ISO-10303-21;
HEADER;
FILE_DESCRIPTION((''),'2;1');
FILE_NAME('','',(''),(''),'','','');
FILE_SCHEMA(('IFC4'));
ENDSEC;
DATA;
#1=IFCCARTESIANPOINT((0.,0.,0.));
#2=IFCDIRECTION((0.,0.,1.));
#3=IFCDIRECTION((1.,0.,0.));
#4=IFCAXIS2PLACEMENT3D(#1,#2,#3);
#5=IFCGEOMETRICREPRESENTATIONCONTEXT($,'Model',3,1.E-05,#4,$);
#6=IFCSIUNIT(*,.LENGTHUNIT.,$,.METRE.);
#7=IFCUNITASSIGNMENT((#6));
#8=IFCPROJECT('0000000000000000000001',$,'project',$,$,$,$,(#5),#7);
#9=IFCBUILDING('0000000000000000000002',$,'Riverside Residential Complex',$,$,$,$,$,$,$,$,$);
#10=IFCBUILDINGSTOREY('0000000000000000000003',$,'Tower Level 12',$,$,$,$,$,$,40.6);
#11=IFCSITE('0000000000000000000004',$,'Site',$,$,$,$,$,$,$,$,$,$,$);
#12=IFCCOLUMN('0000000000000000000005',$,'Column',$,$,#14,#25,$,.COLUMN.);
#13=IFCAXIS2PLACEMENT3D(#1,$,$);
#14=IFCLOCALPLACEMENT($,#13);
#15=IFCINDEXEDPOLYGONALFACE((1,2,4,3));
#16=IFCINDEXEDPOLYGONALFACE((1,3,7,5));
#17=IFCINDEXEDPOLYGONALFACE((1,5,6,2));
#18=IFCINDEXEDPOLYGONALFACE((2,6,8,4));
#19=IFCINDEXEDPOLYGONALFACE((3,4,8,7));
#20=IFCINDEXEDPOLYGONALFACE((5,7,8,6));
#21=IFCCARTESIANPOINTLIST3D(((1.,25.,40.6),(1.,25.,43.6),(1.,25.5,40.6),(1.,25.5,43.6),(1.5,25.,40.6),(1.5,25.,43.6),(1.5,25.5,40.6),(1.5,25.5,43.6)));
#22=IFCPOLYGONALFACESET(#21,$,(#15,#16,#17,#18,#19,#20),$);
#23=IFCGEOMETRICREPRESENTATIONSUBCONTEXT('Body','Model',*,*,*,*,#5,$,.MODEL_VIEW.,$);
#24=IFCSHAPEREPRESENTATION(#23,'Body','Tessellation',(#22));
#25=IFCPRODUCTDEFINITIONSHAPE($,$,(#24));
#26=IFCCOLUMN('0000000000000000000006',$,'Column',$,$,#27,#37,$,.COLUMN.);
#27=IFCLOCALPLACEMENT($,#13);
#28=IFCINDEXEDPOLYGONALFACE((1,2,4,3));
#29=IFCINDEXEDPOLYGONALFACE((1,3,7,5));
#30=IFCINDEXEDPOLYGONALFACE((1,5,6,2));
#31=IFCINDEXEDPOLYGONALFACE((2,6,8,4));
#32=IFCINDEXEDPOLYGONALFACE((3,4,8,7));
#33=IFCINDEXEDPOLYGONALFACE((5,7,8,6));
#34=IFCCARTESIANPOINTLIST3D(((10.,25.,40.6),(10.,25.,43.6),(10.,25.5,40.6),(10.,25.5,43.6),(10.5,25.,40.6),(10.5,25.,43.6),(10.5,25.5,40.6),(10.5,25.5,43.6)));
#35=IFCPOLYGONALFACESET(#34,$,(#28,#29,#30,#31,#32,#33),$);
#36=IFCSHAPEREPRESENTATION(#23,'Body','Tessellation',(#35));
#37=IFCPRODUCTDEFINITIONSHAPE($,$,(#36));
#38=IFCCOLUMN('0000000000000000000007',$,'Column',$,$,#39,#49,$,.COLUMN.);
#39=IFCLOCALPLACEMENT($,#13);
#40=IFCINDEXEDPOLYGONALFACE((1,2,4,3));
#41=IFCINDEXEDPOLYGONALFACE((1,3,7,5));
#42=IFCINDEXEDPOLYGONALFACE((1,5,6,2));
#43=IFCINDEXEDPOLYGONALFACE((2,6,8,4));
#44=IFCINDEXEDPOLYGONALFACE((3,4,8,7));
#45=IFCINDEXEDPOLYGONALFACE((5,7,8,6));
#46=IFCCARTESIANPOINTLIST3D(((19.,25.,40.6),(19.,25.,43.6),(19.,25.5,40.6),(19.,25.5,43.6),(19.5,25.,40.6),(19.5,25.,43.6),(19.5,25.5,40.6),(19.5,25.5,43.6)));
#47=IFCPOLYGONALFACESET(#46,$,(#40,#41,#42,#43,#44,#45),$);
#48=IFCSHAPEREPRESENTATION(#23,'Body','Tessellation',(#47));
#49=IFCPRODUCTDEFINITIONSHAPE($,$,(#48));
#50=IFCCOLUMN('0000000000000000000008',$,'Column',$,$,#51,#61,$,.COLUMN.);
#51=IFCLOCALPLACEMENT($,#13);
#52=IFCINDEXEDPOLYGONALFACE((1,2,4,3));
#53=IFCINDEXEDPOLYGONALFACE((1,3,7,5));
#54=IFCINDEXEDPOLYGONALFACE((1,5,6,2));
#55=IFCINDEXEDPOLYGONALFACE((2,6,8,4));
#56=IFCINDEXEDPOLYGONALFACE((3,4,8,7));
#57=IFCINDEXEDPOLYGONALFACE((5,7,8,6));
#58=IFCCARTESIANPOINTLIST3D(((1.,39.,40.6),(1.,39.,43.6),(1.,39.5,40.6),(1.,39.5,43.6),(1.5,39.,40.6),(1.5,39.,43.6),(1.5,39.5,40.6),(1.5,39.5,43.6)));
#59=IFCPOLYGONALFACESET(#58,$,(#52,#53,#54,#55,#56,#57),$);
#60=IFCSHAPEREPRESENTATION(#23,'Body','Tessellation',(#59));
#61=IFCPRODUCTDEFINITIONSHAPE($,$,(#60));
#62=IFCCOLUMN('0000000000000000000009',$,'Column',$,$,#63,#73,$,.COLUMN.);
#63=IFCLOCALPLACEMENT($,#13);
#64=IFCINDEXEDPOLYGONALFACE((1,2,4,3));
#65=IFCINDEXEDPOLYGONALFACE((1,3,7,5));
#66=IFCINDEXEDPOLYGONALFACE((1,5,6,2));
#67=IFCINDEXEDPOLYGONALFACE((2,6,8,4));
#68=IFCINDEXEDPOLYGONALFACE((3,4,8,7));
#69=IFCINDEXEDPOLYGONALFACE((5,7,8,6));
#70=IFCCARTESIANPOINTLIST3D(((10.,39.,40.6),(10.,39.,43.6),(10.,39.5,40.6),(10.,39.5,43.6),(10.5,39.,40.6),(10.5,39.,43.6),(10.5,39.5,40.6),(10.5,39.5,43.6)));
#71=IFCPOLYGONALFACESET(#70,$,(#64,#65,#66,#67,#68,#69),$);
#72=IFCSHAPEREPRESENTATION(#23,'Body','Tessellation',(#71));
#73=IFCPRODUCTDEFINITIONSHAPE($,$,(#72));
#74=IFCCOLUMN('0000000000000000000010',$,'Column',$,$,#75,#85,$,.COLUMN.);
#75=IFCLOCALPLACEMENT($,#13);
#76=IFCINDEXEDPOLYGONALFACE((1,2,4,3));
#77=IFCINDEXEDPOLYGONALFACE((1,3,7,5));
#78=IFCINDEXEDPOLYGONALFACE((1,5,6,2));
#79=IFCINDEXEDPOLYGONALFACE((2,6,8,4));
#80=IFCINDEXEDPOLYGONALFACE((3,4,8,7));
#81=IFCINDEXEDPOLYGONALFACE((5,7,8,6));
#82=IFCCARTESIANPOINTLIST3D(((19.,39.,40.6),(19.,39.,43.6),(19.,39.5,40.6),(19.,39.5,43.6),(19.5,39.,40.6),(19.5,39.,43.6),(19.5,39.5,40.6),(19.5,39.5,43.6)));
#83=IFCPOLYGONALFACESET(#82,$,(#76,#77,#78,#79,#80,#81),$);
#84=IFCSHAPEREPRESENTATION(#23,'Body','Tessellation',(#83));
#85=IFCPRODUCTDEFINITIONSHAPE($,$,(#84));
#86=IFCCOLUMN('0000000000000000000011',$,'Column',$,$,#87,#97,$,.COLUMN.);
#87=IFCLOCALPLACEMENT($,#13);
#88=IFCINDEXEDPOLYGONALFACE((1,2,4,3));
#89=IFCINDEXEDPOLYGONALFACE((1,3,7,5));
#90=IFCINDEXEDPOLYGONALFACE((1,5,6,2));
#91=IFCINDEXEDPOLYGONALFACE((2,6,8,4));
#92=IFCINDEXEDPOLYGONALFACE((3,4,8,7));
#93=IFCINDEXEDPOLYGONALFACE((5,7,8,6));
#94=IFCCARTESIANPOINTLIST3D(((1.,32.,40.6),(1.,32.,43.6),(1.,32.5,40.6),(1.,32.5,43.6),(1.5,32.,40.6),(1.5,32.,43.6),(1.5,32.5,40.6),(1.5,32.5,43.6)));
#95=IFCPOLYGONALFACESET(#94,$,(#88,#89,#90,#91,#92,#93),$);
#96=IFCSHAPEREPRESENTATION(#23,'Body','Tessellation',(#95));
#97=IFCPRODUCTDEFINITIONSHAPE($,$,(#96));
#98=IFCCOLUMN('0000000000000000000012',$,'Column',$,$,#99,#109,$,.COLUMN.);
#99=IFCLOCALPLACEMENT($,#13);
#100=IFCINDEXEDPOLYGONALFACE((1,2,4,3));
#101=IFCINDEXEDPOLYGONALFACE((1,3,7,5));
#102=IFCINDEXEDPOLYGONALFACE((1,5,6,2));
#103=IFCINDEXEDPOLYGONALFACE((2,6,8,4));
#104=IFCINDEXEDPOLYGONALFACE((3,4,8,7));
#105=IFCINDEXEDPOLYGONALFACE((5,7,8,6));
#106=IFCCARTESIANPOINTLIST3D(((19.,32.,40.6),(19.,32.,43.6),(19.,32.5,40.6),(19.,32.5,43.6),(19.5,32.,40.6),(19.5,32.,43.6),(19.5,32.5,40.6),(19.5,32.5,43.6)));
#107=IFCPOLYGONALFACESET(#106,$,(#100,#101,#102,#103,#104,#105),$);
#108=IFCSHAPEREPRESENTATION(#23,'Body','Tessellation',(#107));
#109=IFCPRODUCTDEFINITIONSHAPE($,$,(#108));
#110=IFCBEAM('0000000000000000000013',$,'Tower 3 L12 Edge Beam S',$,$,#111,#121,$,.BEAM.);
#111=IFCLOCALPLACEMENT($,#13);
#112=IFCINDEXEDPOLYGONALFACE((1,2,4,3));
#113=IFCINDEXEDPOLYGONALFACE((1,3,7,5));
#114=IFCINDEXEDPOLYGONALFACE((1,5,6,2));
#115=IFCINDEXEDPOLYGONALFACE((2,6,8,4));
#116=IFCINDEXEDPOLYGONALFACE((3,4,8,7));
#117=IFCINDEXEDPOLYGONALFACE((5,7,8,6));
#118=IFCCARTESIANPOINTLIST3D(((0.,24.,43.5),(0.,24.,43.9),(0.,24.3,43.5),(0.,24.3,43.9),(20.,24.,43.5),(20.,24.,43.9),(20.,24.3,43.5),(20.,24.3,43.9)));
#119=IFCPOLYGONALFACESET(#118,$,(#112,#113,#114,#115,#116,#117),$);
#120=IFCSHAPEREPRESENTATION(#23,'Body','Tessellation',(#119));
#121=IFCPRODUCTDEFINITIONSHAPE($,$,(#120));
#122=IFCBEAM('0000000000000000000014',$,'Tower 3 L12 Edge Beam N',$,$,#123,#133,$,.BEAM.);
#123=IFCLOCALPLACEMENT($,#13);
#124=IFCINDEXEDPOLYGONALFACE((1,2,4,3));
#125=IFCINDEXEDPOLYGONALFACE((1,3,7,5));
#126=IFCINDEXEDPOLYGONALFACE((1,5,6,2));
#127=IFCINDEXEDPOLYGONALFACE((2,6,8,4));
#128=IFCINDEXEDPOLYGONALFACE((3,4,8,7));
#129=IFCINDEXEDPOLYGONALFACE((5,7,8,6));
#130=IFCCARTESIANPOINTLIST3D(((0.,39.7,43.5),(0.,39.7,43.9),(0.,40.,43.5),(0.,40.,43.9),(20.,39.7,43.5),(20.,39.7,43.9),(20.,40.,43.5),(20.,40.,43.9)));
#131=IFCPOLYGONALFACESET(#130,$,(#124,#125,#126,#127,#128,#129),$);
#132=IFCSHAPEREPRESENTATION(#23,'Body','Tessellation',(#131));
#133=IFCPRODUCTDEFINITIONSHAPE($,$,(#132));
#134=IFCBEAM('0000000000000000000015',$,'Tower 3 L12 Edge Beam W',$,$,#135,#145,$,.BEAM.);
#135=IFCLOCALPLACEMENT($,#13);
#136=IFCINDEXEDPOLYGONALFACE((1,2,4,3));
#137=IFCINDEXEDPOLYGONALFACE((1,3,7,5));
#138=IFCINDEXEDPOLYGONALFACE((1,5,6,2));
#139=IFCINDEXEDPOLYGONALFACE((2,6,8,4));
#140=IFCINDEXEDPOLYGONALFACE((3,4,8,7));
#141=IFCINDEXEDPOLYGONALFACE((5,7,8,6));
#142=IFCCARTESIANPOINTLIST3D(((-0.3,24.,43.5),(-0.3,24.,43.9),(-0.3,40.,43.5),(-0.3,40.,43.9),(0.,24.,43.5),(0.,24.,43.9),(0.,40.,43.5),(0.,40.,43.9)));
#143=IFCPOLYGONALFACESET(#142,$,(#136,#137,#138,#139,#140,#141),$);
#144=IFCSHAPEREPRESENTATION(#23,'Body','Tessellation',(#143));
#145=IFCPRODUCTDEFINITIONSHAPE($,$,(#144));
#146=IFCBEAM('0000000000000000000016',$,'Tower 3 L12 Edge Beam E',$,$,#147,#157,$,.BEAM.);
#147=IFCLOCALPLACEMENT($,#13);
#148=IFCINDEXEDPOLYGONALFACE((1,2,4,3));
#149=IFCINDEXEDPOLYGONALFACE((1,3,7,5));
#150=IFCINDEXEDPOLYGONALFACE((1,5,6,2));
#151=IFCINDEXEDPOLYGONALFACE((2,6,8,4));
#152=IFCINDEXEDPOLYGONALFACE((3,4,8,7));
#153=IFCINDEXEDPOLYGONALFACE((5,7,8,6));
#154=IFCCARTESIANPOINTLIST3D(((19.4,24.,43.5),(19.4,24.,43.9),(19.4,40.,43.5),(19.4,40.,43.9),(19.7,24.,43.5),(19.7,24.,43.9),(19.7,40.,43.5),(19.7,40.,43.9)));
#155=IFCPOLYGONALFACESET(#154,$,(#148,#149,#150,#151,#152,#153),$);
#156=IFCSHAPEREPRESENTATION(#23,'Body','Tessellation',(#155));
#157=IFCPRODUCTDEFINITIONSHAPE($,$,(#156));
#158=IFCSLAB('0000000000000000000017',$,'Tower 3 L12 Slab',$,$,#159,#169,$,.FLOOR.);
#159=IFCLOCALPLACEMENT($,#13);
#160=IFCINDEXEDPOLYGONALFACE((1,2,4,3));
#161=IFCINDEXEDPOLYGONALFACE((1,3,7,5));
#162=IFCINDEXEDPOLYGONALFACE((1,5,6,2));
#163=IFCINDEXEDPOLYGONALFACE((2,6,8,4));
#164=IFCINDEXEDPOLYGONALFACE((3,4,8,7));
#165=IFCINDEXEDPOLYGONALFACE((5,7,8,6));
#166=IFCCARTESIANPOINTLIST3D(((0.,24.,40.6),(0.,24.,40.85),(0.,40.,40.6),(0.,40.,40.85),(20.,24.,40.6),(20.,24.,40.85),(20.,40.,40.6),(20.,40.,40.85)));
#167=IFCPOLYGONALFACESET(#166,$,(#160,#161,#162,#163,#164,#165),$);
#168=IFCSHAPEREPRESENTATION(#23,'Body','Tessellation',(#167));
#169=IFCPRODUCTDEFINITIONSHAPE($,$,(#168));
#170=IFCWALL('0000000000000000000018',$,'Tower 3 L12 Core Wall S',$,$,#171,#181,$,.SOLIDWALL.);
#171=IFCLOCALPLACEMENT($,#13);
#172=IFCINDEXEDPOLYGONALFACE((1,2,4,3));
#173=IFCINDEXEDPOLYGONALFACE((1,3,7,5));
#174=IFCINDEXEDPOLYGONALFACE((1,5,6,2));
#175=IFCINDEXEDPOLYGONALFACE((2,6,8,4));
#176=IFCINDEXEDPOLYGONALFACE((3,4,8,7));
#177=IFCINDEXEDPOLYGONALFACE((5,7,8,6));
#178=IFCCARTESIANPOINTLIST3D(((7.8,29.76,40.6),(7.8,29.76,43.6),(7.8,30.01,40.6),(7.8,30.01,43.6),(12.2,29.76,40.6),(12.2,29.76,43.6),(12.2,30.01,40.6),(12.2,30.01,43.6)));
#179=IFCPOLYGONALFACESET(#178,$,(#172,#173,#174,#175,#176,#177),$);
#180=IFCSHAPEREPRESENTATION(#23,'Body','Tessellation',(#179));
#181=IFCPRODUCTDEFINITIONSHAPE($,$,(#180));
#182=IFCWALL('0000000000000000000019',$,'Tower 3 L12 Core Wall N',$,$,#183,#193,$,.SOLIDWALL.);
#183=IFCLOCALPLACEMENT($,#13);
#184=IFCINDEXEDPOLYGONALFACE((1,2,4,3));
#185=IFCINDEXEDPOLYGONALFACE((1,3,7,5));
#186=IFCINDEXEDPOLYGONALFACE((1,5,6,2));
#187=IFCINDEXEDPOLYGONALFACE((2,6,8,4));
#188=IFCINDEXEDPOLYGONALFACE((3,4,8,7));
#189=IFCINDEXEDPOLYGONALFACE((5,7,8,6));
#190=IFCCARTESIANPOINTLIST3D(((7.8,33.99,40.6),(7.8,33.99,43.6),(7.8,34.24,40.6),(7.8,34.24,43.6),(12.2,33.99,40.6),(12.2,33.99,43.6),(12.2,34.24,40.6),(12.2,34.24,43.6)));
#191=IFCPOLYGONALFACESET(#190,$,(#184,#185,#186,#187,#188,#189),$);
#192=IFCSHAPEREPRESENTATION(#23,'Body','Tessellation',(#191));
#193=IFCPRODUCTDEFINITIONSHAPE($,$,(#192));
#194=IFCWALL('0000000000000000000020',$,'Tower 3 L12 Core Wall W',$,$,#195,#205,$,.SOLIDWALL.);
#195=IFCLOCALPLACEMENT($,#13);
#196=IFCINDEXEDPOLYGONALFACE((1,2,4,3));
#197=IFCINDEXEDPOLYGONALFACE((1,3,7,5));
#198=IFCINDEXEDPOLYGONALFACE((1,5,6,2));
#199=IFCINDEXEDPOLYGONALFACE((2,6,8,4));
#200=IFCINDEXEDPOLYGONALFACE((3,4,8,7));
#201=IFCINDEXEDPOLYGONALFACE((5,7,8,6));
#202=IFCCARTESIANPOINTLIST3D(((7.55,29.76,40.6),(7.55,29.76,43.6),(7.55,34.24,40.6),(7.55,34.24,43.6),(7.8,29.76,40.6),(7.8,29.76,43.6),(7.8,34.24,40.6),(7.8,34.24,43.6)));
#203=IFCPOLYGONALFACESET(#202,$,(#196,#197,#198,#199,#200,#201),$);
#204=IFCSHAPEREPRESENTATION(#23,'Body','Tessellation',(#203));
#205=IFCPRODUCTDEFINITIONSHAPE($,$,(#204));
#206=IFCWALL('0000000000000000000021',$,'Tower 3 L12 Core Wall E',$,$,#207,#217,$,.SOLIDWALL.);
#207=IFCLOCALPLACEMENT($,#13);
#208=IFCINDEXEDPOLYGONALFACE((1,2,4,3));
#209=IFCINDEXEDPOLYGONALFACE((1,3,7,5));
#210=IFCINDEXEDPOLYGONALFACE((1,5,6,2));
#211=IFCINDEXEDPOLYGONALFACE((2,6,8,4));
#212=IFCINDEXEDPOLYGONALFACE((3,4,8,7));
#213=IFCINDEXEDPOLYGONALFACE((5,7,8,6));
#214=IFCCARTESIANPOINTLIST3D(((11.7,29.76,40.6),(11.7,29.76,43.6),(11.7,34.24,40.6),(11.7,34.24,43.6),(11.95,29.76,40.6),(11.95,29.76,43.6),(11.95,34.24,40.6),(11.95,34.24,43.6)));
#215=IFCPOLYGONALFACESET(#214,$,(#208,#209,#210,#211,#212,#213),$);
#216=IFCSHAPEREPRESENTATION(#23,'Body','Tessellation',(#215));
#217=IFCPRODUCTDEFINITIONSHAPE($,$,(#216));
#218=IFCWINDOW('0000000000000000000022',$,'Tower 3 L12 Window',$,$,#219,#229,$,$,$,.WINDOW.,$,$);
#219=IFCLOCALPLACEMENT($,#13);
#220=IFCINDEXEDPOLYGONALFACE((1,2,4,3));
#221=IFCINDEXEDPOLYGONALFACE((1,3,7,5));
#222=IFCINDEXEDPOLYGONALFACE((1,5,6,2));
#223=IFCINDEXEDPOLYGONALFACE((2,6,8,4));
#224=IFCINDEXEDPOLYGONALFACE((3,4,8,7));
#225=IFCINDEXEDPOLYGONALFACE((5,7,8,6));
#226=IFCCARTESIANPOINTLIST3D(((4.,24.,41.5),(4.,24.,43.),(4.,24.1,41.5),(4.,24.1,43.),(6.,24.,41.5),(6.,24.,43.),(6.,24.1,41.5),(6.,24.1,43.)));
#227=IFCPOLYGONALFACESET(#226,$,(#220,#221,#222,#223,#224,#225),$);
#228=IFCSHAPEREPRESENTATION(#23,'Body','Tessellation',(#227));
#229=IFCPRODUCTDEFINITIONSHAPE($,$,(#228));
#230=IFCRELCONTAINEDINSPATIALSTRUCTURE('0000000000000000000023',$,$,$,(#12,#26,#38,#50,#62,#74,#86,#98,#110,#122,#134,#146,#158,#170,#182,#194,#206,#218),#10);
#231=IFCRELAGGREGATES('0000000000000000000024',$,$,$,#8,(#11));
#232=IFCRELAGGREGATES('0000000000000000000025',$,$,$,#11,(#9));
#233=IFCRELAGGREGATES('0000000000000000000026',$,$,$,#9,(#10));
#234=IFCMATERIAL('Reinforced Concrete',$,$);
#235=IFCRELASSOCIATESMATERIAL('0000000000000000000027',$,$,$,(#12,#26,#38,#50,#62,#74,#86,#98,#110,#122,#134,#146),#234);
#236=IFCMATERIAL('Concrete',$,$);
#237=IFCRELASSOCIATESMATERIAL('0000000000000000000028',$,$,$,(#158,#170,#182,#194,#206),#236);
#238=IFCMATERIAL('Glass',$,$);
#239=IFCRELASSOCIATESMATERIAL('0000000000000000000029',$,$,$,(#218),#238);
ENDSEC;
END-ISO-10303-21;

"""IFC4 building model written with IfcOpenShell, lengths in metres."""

from ifc_helpers import new_model, si_unit, frame, origin_with_axes, place, context, subcontext, project, spatial, line, indexed_curve, outline, extrude, material, element, save


model = new_model("IFC4")

# Units and contexts
model_context = context("Model", 3, precision=1e-05, world=origin_with_axes())
body_context = subcontext(model_context, "Body", "Model", "MODEL_VIEW")
ifc_project = project(units=[si_unit("LENGTHUNIT", "METRE")], contexts=[model_context])

# Site, building, storey
site = spatial("IfcSite", under=ifc_project, Name="Site")
building = spatial("IfcBuilding", under=site, Name="Riverside Residential Complex")
storey = spatial("IfcBuildingStorey", under=building, Name="Tower Level 12", Elevation=40.6)

# Columns
ifc_material_1 = material(Name="Reinforced Concrete")
for number, where, z_axis, x_axis, name in (
    (1, (1.0, 25.0, 40.6), (0.0, 0.0, 1.0), (1.0, 0.0, 0.0), "Column"),
    (2, (10.0, 25.0, 40.6), (0.0, 0.0, 1.0), (1.0, 0.0, 0.0), "Column"),
    (3, (19.0, 25.0, 40.6), (0.0, 0.0, 1.0), (1.0, 0.0, 0.0), "Column"),
    (4, (1.0, 39.0, 40.6), (0.0, 0.0, 1.0), (1.0, 0.0, 0.0), "Column"),
    (5, (10.0, 39.0, 40.6), (0.0, 0.0, 1.0), (1.0, 0.0, 0.0), "Column"),
    (6, (19.0, 39.0, 40.6), (0.0, 0.0, 1.0), (1.0, 0.0, 0.0), "Column"),
    (7, (1.0, 32.0, 40.6), (0.0, 0.0, 1.0), (1.0, 0.0, 0.0), "Column"),
    (8, (19.0, 32.0, 40.6), (0.0, 0.0, 1.0), (1.0, 0.0, 0.0), "Column"),
):
    element("IfcColumn", number, at=place(None, frame(where, z_axis=z_axis, x_axis=x_axis)), inside=storey, material=ifc_material_1, Name=name, PredefinedType="COLUMN", context=body_context, shape_type="SweptSolid", body=[
        extrude(outline(indexed_curve([(0.0, 0.0), (0.5, 0.0), (0.5, 0.5), (0.0, 0.5)], segments=[line(1, 2, 3, 4, 1)])), origin_with_axes(), (0.0, 0.0, 1.0), 3.0),
    ])

# Beams
for number, where, z_axis, x_axis, name in (
    (9, (0.0, 24.0, 43.5), (0.0, 0.0, 1.0), (1.0, 0.0, 0.0), "Tower 3 L12 Edge Beam S"),
    (10, (0.0, 39.7, 43.5), (0.0, 0.0, 1.0), (1.0, 0.0, 0.0), "Tower 3 L12 Edge Beam N"),
):
    element("IfcBeam", number, at=place(None, frame(where, z_axis=z_axis, x_axis=x_axis)), inside=storey, material=ifc_material_1, Name=name, PredefinedType="BEAM", context=body_context, shape_type="SweptSolid", body=[
        extrude(outline(indexed_curve([(0.0, 0.0), (20.0, 0.0), (20.0, 0.3), (0.0, 0.3)], segments=[line(1, 2, 3, 4, 1)])), origin_with_axes(), (0.0, 0.0, 1.0), 0.4),
    ])
for number, where, z_axis, x_axis, name in (
    (11, (0.0, 24.0, 43.5), (0.0, 0.0, 1.0), (0.0, 1.0, 0.0), "Tower 3 L12 Edge Beam W"),
    (12, (19.7, 24.0, 43.5), (0.0, 0.0, 1.0), (0.0, 1.0, 0.0), "Tower 3 L12 Edge Beam E"),
):
    element("IfcBeam", number, at=place(None, frame(where, z_axis=z_axis, x_axis=x_axis)), inside=storey, material=ifc_material_1, Name=name, PredefinedType="BEAM", context=body_context, shape_type="SweptSolid", body=[
        extrude(outline(indexed_curve([(0.0, 0.0), (16.0, 0.0), (16.0, 0.3), (0.0, 0.3)], segments=[line(1, 2, 3, 4, 1)])), origin_with_axes(), (0.0, 0.0, 1.0), 0.4),
    ])

# Slab
ifc_material_2 = material(Name="Concrete")
slab_placement = place(None, frame((0.0, 24.0, 40.6), z_axis=(0.0, 0.0, 1.0), x_axis=(1.0, 0.0, 0.0)))
element("IfcSlab", 13, at=slab_placement, inside=storey, material=ifc_material_2, Name="Tower 3 L12 Slab", PredefinedType="FLOOR", context=body_context, shape_type="SweptSolid", body=[
    extrude(outline(indexed_curve([(0.0, 0.0), (20.0, 0.0), (20.0, 16.0), (0.0, 16.0)], segments=[line(1, 2, 3, 4, 1)])), origin_with_axes(), (0.0, 0.0, 1.0), 0.25),
])

# Walls
for number, where, z_axis, x_axis, name in (
    (14, (7.8, 29.76, 40.6), (0.0, 0.0, 1.0), (1.0, 0.0, 0.0), "Tower 3 L12 Core Wall S"),
    (15, (7.8, 33.99, 40.6), (0.0, 0.0, 1.0), (1.0, 0.0, 0.0), "Tower 3 L12 Core Wall N"),
):
    element("IfcWall", number, at=place(None, frame(where, z_axis=z_axis, x_axis=x_axis)), inside=storey, material=ifc_material_2, Name=name, PredefinedType="SOLIDWALL", context=body_context, shape_type="SweptSolid", body=[
        extrude(outline(indexed_curve([(0.0, 0.0), (4.4, 0.0), (4.4, 0.25), (0.0, 0.25)], segments=[line(1, 2, 3, 4, 1)])), origin_with_axes(), (0.0, 0.0, 1.0), 3.0),
    ])
for number, where, z_axis, x_axis, name in (
    (16, (7.8, 29.76, 40.6), (0.0, 0.0, 1.0), (0.0, 1.0, 0.0), "Tower 3 L12 Core Wall W"),
    (17, (11.95, 29.76, 40.6), (0.0, 0.0, 1.0), (0.0, 1.0, 0.0), "Tower 3 L12 Core Wall E"),
):
    element("IfcWall", number, at=place(None, frame(where, z_axis=z_axis, x_axis=x_axis)), inside=storey, material=ifc_material_2, Name=name, PredefinedType="SOLIDWALL", context=body_context, shape_type="SweptSolid", body=[
        extrude(outline(indexed_curve([(0.0, 0.0), (4.48, 0.0), (4.48, 0.25), (0.0, 0.25)], segments=[line(1, 2, 3, 4, 1)])), origin_with_axes(), (0.0, 0.0, 1.0), 3.0),
    ])

# Window
ifc_material_3 = material(Name="Glass")
for number, where, z_axis, x_axis, name in (
    (18, (4.0, 24.0, 41.5), (0.0, 0.0, 1.0), (1.0, 0.0, 0.0), "Tower 3 L12 Window"),
):
    element("IfcWindow", number, at=place(None, frame(where, z_axis=z_axis, x_axis=x_axis)), inside=storey, material=ifc_material_3, Name=name, PredefinedType="WINDOW", context=body_context, shape_type="SweptSolid", body=[
        extrude(outline(indexed_curve([(0.0, 0.0), (2.0, 0.0), (2.0, 0.1), (0.0, 0.1)], segments=[line(1, 2, 3, 4, 1)])), origin_with_axes(), (0.0, 0.0, 1.0), 1.5),
    ])

save(model, "model.ifc")
